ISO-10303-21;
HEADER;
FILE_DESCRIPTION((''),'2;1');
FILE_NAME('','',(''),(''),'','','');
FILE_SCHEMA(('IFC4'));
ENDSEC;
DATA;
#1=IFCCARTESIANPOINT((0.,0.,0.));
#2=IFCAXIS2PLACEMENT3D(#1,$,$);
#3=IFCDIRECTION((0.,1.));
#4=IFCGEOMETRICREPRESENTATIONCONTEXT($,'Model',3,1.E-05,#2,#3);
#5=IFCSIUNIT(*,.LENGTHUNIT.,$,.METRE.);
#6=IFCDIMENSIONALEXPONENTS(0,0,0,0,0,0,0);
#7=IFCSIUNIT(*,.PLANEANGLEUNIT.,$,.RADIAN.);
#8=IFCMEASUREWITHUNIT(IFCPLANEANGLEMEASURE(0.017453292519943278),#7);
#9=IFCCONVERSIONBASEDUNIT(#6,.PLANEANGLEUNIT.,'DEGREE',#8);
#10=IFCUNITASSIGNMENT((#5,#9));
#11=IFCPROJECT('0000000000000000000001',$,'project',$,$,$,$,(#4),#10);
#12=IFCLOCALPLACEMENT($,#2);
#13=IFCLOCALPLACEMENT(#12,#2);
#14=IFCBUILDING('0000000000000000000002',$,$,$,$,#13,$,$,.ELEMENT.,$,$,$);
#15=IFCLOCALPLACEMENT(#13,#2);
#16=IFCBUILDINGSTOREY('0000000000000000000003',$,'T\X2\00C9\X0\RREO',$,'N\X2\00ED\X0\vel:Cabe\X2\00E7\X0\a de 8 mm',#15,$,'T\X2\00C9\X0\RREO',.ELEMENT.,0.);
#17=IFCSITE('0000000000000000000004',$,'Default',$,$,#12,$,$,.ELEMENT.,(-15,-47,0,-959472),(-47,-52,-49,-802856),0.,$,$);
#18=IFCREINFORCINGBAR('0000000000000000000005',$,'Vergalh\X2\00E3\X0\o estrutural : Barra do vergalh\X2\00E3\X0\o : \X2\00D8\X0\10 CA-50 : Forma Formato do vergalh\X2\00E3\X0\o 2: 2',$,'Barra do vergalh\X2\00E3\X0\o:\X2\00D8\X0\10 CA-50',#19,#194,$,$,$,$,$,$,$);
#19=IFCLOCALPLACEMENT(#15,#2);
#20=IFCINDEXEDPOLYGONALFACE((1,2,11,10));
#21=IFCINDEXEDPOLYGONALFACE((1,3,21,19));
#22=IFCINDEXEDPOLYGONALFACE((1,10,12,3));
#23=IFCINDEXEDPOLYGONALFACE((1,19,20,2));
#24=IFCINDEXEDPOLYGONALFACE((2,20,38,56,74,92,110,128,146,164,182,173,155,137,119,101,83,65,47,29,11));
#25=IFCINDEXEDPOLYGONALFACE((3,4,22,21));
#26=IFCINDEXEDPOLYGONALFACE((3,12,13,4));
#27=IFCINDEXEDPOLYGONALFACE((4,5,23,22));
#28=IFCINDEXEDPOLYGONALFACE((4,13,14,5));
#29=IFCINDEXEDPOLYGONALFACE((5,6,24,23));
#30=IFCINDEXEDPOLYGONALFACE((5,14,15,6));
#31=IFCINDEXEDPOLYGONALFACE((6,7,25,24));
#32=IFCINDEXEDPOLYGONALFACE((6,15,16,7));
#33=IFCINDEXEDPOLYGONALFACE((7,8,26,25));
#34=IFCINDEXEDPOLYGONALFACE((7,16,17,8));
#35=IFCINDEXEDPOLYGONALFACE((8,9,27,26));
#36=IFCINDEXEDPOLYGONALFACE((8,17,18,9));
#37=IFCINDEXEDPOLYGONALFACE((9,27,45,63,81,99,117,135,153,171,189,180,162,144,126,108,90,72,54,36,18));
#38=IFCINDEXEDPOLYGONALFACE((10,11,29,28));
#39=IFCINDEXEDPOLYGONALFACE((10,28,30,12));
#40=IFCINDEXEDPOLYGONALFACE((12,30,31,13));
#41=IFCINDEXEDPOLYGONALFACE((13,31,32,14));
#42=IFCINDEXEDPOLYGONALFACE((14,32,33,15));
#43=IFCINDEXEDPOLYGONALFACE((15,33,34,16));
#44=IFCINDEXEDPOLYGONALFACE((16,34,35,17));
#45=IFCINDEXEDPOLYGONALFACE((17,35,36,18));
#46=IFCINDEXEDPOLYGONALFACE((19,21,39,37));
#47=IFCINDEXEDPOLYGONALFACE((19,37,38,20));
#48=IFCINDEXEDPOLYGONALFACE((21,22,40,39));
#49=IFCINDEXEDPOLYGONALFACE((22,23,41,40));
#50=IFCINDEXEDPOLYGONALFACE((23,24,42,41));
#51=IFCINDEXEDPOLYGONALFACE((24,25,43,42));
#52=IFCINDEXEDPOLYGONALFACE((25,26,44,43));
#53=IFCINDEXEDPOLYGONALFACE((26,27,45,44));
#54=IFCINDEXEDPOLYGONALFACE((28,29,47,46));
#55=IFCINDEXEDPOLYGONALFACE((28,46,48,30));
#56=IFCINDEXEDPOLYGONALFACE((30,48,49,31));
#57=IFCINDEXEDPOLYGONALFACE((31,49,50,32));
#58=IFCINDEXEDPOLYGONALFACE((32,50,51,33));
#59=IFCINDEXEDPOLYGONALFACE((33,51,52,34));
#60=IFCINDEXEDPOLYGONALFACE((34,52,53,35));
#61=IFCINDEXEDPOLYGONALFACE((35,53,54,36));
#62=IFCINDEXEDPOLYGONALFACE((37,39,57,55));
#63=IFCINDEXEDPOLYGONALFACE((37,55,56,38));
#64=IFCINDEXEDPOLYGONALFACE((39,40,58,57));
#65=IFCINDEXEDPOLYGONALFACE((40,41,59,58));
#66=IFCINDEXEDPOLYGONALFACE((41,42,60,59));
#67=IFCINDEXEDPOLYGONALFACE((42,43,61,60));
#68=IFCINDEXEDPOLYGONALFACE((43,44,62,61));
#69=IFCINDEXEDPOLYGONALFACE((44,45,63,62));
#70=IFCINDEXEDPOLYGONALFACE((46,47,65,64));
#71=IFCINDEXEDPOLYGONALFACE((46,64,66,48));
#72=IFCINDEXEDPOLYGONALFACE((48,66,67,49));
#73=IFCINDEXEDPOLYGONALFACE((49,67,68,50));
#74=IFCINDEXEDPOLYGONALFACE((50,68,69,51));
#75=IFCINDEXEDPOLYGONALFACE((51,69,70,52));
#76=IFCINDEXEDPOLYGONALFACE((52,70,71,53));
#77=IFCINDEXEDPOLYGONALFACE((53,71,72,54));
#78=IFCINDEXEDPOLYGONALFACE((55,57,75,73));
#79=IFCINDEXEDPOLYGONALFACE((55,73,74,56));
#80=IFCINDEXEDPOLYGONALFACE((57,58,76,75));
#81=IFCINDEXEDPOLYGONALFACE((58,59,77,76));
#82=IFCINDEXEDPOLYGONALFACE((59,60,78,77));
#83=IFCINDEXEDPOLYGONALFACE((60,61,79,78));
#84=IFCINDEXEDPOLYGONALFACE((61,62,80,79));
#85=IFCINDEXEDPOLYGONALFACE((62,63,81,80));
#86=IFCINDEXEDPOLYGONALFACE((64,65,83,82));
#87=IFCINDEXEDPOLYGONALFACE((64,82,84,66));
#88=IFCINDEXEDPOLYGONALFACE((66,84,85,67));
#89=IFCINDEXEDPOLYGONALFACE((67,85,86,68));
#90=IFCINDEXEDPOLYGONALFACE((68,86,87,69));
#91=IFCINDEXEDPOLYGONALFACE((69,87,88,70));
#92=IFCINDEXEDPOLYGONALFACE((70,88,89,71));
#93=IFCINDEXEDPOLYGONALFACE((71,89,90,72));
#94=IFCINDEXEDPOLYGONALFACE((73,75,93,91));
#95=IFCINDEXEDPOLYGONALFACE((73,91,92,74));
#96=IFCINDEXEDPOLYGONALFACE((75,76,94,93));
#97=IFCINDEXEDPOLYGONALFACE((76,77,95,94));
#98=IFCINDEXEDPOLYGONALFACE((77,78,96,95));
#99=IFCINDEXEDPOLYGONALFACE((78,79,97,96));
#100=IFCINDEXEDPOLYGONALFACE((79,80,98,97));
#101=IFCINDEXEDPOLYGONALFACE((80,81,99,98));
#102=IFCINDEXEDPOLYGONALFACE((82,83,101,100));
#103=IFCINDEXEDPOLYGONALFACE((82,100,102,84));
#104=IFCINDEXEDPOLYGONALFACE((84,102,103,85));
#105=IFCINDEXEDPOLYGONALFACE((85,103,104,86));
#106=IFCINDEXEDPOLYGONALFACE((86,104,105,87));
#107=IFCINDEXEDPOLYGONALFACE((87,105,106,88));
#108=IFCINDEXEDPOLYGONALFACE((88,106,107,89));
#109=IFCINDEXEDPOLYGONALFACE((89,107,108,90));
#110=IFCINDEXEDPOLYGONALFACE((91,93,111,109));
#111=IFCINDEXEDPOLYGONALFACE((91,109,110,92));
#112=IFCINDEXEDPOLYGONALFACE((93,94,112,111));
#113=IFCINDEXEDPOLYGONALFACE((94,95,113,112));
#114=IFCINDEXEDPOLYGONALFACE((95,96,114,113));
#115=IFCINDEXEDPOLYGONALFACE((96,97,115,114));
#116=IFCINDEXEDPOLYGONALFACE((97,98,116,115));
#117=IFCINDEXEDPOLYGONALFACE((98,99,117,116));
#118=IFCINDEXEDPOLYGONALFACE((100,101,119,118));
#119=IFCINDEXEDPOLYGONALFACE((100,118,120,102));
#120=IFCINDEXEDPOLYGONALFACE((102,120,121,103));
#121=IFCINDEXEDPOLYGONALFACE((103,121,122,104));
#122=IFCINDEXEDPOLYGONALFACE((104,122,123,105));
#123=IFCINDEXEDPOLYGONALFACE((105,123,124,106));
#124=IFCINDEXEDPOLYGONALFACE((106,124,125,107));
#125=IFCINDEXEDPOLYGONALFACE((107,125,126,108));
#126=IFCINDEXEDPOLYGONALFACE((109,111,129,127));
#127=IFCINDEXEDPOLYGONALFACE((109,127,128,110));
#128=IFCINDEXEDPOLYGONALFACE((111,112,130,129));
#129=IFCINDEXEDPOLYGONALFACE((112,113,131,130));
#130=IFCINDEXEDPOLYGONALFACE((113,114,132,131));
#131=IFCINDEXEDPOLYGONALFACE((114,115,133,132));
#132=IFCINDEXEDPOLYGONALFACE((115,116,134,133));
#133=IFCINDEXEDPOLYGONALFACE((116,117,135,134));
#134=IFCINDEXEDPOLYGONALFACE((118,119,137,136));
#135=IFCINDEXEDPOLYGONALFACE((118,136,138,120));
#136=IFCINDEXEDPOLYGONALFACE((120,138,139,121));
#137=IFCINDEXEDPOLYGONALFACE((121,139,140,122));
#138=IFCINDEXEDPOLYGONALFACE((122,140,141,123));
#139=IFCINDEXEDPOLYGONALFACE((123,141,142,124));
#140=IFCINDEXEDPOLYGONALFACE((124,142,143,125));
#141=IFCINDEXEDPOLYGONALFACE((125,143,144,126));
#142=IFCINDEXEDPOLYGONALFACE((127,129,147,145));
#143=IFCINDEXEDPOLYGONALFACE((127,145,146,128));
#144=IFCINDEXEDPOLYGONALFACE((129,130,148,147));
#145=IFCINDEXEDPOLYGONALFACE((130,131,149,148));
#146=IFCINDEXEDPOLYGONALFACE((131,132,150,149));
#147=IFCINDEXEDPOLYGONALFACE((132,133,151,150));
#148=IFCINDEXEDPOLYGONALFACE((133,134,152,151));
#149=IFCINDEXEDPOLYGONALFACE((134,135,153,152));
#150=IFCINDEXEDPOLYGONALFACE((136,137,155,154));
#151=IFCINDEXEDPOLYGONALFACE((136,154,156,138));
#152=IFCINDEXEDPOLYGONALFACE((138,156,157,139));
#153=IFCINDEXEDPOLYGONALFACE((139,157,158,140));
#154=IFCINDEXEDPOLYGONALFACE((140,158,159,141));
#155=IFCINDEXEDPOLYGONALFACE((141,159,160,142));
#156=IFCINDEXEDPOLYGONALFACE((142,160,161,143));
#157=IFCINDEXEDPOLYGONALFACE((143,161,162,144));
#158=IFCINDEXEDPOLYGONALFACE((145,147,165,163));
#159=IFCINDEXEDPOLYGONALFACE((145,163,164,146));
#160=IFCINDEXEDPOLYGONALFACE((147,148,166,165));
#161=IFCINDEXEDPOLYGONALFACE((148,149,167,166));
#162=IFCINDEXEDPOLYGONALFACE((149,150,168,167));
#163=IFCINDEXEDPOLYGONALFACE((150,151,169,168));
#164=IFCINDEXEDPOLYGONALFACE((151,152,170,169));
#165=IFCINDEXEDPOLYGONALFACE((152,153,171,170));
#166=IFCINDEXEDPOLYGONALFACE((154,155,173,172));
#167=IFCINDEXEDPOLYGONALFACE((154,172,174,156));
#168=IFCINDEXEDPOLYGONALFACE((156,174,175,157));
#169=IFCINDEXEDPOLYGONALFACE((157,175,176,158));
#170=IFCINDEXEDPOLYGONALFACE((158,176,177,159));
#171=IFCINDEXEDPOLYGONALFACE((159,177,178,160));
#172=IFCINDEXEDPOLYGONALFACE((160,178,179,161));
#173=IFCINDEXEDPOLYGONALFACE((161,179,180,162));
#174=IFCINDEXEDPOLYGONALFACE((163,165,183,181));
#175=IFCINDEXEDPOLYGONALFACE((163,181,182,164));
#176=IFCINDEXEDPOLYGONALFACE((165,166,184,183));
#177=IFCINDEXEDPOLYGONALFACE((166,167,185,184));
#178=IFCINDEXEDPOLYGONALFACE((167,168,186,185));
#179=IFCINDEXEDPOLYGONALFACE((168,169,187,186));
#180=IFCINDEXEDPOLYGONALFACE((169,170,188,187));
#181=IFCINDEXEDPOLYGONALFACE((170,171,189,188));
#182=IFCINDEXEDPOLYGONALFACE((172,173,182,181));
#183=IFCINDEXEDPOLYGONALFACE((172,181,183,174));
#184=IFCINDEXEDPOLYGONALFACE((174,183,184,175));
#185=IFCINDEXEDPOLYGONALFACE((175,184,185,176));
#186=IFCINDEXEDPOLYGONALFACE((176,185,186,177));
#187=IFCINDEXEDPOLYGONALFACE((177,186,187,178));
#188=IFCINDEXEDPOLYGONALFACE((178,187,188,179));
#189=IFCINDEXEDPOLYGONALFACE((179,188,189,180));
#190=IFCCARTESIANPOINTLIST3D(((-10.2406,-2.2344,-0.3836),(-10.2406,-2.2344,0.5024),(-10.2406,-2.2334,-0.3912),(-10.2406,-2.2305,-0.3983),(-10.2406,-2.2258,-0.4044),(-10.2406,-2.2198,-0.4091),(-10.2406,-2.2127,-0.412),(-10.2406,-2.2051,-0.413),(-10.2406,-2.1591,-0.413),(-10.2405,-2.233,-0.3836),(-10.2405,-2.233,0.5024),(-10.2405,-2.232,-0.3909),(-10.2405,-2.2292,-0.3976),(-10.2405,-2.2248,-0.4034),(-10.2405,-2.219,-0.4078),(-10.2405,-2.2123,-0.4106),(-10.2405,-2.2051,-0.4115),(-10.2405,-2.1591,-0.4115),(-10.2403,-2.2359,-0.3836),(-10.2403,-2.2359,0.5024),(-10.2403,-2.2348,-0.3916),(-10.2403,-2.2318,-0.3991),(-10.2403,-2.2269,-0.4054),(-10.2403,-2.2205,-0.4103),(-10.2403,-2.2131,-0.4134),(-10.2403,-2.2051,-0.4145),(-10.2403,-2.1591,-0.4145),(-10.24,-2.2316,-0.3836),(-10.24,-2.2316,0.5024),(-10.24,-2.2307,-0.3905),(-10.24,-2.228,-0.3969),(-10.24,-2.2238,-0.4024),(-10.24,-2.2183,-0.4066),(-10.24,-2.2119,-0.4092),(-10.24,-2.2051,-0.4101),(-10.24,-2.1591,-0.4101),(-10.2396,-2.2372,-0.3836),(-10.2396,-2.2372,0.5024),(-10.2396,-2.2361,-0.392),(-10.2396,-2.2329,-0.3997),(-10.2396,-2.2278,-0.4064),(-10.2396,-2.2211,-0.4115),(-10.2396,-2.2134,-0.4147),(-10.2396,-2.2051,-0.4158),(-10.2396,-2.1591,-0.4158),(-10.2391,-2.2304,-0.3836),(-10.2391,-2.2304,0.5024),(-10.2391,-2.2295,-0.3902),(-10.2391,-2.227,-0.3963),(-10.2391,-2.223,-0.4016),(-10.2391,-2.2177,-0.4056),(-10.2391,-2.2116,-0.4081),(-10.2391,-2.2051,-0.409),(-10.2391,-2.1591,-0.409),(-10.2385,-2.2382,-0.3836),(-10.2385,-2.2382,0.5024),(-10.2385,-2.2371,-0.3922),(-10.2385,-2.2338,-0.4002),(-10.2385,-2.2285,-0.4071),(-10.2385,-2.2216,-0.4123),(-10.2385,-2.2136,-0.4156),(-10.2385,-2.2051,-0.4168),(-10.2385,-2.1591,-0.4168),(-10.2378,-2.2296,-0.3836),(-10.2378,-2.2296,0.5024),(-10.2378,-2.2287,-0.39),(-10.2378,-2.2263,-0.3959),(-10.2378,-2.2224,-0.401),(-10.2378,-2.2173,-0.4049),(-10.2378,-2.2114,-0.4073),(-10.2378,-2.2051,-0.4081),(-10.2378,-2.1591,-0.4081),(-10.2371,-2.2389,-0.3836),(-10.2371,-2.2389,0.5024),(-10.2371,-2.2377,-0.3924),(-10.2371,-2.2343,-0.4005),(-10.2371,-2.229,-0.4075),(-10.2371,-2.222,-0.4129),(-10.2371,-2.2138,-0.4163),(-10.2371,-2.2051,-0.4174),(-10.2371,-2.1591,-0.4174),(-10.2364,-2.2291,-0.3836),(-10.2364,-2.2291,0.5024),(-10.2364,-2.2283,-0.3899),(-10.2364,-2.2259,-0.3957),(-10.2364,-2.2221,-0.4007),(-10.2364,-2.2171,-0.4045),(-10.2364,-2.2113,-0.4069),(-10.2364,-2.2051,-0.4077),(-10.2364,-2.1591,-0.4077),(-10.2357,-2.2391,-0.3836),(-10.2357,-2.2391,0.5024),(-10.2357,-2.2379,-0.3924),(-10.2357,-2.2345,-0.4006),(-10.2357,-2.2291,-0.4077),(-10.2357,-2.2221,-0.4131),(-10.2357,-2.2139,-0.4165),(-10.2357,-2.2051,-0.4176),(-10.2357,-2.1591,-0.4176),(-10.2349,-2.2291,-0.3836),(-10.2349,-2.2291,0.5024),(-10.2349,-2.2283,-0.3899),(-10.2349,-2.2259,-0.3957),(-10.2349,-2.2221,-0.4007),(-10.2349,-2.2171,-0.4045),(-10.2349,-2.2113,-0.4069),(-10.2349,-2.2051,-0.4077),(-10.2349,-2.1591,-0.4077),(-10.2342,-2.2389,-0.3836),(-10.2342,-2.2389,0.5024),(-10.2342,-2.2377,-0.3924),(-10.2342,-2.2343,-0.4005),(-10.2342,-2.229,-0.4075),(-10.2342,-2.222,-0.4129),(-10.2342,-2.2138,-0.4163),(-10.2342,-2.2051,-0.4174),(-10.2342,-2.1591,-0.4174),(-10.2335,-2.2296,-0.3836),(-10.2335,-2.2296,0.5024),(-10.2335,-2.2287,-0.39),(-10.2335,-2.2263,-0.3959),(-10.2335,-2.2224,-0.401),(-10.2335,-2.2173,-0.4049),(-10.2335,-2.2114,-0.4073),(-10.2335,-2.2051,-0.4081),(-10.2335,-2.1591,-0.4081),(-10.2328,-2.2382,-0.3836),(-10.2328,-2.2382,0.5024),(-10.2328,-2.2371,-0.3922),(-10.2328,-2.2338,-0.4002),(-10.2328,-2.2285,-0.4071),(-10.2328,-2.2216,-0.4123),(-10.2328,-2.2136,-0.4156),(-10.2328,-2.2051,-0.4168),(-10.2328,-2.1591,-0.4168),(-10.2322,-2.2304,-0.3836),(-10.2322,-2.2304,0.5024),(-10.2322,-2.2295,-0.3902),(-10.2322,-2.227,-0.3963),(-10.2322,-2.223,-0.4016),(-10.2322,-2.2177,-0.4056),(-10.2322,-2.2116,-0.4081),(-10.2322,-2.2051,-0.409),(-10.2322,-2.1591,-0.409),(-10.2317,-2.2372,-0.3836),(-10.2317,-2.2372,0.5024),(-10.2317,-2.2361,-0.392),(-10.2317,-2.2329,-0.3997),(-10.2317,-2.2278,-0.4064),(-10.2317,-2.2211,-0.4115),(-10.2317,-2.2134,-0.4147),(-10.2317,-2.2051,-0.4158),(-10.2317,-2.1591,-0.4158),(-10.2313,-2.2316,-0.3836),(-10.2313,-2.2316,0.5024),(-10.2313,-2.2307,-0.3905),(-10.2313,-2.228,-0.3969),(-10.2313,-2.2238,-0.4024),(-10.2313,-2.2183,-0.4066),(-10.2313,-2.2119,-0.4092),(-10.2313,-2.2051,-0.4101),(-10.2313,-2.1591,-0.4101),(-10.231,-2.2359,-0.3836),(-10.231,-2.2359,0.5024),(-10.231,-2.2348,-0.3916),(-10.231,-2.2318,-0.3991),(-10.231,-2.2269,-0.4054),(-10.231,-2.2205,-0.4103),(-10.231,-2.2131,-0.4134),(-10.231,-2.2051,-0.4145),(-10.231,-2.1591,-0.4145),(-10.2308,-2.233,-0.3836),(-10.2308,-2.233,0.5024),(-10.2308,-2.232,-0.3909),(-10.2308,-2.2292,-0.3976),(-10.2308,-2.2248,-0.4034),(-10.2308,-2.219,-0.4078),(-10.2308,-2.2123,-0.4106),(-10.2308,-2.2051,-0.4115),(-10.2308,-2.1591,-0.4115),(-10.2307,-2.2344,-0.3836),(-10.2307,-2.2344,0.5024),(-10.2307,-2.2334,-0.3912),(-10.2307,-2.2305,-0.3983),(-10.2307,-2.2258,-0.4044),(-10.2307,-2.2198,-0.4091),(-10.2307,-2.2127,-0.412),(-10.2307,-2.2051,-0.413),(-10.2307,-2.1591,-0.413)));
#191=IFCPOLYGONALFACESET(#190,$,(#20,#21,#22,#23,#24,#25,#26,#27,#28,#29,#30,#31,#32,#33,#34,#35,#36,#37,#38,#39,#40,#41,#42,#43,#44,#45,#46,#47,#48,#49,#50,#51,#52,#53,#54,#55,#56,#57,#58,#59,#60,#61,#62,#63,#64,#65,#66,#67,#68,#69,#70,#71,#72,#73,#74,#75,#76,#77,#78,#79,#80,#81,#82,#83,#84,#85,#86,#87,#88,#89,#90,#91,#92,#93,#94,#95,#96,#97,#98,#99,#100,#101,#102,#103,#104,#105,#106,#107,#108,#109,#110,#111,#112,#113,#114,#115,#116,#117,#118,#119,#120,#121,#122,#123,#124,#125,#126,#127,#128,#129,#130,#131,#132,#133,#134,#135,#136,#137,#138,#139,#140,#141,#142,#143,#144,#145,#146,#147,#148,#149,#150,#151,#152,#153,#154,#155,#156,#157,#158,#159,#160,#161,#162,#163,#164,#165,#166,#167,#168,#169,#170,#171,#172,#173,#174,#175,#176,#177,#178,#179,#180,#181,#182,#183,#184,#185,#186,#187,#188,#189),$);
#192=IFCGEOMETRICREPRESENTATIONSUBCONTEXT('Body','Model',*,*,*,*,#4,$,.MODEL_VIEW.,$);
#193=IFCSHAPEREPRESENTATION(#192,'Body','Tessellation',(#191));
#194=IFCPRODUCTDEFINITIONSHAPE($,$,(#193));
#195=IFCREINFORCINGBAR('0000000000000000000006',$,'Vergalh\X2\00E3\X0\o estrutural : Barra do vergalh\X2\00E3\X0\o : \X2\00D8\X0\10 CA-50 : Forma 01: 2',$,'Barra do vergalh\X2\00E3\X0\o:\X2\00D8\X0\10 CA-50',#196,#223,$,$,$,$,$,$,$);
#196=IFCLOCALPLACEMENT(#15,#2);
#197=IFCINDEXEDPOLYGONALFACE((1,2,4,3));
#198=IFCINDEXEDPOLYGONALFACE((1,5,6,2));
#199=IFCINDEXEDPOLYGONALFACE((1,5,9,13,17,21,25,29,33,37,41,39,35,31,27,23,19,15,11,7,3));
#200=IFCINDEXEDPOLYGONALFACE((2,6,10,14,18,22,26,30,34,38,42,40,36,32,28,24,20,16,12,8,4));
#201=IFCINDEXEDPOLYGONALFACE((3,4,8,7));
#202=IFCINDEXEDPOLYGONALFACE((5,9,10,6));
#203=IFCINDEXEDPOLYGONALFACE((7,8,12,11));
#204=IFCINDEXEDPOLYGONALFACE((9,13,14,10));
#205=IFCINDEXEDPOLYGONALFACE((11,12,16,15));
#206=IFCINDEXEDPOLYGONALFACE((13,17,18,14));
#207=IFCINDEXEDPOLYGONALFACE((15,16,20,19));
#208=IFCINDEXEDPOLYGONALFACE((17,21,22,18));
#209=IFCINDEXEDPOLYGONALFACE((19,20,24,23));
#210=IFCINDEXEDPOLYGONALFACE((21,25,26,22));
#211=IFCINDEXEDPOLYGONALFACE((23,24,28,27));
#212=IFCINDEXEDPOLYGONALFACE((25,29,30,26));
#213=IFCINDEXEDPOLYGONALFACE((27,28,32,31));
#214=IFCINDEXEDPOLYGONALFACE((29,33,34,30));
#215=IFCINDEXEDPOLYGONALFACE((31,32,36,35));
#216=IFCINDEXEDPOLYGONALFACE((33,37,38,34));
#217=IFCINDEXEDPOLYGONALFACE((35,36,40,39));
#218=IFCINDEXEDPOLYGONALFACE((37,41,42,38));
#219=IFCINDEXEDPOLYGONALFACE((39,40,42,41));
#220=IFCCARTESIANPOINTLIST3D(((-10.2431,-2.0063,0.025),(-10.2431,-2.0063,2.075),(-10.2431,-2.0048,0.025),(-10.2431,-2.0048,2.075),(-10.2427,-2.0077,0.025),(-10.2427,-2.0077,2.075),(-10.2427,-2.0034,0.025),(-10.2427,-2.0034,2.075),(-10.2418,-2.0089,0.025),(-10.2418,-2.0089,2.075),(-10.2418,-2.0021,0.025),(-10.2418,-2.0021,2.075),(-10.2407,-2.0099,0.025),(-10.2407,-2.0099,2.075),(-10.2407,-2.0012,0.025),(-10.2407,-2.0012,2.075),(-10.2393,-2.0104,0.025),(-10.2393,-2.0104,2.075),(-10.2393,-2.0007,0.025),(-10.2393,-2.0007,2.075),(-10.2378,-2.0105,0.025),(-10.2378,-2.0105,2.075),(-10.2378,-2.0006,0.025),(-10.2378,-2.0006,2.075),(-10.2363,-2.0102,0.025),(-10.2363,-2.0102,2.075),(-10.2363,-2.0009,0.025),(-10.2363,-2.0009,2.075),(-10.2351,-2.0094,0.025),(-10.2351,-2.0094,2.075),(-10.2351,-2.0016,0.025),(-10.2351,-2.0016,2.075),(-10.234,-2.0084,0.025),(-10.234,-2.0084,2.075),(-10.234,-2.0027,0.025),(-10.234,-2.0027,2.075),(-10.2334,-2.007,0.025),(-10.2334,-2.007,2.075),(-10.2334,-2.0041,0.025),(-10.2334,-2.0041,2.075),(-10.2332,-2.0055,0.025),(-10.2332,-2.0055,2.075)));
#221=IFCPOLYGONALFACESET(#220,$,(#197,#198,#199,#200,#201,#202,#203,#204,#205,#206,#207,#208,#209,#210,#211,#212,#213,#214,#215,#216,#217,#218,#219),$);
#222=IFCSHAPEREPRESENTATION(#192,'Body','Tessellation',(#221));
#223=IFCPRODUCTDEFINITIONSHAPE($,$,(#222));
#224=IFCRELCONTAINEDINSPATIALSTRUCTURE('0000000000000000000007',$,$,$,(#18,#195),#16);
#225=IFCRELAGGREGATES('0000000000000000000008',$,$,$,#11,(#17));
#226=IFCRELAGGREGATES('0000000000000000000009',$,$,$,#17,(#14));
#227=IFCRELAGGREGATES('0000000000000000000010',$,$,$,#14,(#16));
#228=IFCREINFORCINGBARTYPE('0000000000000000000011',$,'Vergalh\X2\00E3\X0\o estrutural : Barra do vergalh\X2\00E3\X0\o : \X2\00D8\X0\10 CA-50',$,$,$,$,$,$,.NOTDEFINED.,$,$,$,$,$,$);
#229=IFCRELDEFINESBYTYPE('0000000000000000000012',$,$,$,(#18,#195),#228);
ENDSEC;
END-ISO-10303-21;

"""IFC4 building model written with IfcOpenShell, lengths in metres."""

from ifc_helpers import new_model, entity, si_unit, converted_unit, direction, origin, place, context, subcontext, project, spatial, type_object, element, save


model = new_model("IFC4")

# Units and contexts
model_context = context("Model", 3, precision=1e-05, world=origin(), true_north=direction((0.0, 1.0)))
body_context = subcontext(model_context, "Body", "Model", "MODEL_VIEW")
ifc_project = project(units=[si_unit("LENGTHUNIT", "METRE"), converted_unit("PLANEANGLEUNIT", "DEGREE", entity("IfcPlaneAngleMeasure", 0.017453292519943278), si_unit("PLANEANGLEUNIT", "RADIAN"), dimensions=[0, 0, 0, 0, 0, 0, 0])], contexts=[model_context])

# Site, building, storey
site_placement = place(None, origin())
site = spatial("IfcSite", under=ifc_project, at=site_placement, Name="Default", CompositionType="ELEMENT", RefLatitude=(-15, -47, 0, -959472), RefLongitude=(-47, -52, -49, -802856), RefElevation=0.0)
building_placement = place(site_placement, origin())
building = spatial("IfcBuilding", under=site, at=building_placement, CompositionType="ELEMENT")
storey_placement = place(building_placement, origin())
storey = spatial("IfcBuildingStorey", under=building, at=storey_placement, Name="TÉRREO", ObjectType="Nível:Cabeça de 8 mm", LongName="TÉRREO", CompositionType="ELEMENT", Elevation=0.0)

# Reinforcing bars
reinforcing_bar_type_1 = type_object("IfcReinforcingBarType", Name="Vergalhão estrutural : Barra do vergalhão : Ø10 CA-50", PredefinedType="NOTDEFINED")
reinforcing_bar_1_placement = place(storey_placement, origin())
element("IfcReinforcingBar", 1, at=reinforcing_bar_1_placement, inside=storey, type_object=reinforcing_bar_type_1, Name="Vergalhão estrutural : Barra do vergalhão : Ø10 CA-50 : Forma Formato do vergalhão 2: 2", ObjectType="Barra do vergalhão:Ø10 CA-50", context=body_context, shape_type="AdvancedSweptSolid", body=[
    entity("IfcSweptDiskSolid", entity("IfcIndexedPolyCurve", entity("IfcCartesianPointList3D", [[-10.2357, -2.1591, -0.4126], [-10.2357, -2.2051, -0.4126], [-10.2357, -2.2256, -0.4042], [-10.2357, -2.2341, -0.3836], [-10.2357, -2.2341, 0.5024]]), [entity("IfcLineIndex", [1, 2]), entity("IfcArcIndex", [2, 3, 4]), entity("IfcLineIndex", [4, 5])], False), 0.005, None, 0.0, 92.0),
])
reinforcing_bar_2_placement = place(storey_placement, origin())
element("IfcReinforcingBar", 2, at=reinforcing_bar_2_placement, inside=storey, type_object=reinforcing_bar_type_1, Name="Vergalhão estrutural : Barra do vergalhão : Ø10 CA-50 : Forma 01: 2", ObjectType="Barra do vergalhão:Ø10 CA-50", context=body_context, shape_type="AdvancedSweptSolid", body=[
    entity("IfcSweptDiskSolid", entity("IfcIndexedPolyCurve", entity("IfcCartesianPointList3D", [[-10.2382, -2.0055, 0.025], [-10.2382, -2.0055, 2.075]]), None, False), 0.005, None, 0.0, 1.0),
])

save(model, "model.ifc")
